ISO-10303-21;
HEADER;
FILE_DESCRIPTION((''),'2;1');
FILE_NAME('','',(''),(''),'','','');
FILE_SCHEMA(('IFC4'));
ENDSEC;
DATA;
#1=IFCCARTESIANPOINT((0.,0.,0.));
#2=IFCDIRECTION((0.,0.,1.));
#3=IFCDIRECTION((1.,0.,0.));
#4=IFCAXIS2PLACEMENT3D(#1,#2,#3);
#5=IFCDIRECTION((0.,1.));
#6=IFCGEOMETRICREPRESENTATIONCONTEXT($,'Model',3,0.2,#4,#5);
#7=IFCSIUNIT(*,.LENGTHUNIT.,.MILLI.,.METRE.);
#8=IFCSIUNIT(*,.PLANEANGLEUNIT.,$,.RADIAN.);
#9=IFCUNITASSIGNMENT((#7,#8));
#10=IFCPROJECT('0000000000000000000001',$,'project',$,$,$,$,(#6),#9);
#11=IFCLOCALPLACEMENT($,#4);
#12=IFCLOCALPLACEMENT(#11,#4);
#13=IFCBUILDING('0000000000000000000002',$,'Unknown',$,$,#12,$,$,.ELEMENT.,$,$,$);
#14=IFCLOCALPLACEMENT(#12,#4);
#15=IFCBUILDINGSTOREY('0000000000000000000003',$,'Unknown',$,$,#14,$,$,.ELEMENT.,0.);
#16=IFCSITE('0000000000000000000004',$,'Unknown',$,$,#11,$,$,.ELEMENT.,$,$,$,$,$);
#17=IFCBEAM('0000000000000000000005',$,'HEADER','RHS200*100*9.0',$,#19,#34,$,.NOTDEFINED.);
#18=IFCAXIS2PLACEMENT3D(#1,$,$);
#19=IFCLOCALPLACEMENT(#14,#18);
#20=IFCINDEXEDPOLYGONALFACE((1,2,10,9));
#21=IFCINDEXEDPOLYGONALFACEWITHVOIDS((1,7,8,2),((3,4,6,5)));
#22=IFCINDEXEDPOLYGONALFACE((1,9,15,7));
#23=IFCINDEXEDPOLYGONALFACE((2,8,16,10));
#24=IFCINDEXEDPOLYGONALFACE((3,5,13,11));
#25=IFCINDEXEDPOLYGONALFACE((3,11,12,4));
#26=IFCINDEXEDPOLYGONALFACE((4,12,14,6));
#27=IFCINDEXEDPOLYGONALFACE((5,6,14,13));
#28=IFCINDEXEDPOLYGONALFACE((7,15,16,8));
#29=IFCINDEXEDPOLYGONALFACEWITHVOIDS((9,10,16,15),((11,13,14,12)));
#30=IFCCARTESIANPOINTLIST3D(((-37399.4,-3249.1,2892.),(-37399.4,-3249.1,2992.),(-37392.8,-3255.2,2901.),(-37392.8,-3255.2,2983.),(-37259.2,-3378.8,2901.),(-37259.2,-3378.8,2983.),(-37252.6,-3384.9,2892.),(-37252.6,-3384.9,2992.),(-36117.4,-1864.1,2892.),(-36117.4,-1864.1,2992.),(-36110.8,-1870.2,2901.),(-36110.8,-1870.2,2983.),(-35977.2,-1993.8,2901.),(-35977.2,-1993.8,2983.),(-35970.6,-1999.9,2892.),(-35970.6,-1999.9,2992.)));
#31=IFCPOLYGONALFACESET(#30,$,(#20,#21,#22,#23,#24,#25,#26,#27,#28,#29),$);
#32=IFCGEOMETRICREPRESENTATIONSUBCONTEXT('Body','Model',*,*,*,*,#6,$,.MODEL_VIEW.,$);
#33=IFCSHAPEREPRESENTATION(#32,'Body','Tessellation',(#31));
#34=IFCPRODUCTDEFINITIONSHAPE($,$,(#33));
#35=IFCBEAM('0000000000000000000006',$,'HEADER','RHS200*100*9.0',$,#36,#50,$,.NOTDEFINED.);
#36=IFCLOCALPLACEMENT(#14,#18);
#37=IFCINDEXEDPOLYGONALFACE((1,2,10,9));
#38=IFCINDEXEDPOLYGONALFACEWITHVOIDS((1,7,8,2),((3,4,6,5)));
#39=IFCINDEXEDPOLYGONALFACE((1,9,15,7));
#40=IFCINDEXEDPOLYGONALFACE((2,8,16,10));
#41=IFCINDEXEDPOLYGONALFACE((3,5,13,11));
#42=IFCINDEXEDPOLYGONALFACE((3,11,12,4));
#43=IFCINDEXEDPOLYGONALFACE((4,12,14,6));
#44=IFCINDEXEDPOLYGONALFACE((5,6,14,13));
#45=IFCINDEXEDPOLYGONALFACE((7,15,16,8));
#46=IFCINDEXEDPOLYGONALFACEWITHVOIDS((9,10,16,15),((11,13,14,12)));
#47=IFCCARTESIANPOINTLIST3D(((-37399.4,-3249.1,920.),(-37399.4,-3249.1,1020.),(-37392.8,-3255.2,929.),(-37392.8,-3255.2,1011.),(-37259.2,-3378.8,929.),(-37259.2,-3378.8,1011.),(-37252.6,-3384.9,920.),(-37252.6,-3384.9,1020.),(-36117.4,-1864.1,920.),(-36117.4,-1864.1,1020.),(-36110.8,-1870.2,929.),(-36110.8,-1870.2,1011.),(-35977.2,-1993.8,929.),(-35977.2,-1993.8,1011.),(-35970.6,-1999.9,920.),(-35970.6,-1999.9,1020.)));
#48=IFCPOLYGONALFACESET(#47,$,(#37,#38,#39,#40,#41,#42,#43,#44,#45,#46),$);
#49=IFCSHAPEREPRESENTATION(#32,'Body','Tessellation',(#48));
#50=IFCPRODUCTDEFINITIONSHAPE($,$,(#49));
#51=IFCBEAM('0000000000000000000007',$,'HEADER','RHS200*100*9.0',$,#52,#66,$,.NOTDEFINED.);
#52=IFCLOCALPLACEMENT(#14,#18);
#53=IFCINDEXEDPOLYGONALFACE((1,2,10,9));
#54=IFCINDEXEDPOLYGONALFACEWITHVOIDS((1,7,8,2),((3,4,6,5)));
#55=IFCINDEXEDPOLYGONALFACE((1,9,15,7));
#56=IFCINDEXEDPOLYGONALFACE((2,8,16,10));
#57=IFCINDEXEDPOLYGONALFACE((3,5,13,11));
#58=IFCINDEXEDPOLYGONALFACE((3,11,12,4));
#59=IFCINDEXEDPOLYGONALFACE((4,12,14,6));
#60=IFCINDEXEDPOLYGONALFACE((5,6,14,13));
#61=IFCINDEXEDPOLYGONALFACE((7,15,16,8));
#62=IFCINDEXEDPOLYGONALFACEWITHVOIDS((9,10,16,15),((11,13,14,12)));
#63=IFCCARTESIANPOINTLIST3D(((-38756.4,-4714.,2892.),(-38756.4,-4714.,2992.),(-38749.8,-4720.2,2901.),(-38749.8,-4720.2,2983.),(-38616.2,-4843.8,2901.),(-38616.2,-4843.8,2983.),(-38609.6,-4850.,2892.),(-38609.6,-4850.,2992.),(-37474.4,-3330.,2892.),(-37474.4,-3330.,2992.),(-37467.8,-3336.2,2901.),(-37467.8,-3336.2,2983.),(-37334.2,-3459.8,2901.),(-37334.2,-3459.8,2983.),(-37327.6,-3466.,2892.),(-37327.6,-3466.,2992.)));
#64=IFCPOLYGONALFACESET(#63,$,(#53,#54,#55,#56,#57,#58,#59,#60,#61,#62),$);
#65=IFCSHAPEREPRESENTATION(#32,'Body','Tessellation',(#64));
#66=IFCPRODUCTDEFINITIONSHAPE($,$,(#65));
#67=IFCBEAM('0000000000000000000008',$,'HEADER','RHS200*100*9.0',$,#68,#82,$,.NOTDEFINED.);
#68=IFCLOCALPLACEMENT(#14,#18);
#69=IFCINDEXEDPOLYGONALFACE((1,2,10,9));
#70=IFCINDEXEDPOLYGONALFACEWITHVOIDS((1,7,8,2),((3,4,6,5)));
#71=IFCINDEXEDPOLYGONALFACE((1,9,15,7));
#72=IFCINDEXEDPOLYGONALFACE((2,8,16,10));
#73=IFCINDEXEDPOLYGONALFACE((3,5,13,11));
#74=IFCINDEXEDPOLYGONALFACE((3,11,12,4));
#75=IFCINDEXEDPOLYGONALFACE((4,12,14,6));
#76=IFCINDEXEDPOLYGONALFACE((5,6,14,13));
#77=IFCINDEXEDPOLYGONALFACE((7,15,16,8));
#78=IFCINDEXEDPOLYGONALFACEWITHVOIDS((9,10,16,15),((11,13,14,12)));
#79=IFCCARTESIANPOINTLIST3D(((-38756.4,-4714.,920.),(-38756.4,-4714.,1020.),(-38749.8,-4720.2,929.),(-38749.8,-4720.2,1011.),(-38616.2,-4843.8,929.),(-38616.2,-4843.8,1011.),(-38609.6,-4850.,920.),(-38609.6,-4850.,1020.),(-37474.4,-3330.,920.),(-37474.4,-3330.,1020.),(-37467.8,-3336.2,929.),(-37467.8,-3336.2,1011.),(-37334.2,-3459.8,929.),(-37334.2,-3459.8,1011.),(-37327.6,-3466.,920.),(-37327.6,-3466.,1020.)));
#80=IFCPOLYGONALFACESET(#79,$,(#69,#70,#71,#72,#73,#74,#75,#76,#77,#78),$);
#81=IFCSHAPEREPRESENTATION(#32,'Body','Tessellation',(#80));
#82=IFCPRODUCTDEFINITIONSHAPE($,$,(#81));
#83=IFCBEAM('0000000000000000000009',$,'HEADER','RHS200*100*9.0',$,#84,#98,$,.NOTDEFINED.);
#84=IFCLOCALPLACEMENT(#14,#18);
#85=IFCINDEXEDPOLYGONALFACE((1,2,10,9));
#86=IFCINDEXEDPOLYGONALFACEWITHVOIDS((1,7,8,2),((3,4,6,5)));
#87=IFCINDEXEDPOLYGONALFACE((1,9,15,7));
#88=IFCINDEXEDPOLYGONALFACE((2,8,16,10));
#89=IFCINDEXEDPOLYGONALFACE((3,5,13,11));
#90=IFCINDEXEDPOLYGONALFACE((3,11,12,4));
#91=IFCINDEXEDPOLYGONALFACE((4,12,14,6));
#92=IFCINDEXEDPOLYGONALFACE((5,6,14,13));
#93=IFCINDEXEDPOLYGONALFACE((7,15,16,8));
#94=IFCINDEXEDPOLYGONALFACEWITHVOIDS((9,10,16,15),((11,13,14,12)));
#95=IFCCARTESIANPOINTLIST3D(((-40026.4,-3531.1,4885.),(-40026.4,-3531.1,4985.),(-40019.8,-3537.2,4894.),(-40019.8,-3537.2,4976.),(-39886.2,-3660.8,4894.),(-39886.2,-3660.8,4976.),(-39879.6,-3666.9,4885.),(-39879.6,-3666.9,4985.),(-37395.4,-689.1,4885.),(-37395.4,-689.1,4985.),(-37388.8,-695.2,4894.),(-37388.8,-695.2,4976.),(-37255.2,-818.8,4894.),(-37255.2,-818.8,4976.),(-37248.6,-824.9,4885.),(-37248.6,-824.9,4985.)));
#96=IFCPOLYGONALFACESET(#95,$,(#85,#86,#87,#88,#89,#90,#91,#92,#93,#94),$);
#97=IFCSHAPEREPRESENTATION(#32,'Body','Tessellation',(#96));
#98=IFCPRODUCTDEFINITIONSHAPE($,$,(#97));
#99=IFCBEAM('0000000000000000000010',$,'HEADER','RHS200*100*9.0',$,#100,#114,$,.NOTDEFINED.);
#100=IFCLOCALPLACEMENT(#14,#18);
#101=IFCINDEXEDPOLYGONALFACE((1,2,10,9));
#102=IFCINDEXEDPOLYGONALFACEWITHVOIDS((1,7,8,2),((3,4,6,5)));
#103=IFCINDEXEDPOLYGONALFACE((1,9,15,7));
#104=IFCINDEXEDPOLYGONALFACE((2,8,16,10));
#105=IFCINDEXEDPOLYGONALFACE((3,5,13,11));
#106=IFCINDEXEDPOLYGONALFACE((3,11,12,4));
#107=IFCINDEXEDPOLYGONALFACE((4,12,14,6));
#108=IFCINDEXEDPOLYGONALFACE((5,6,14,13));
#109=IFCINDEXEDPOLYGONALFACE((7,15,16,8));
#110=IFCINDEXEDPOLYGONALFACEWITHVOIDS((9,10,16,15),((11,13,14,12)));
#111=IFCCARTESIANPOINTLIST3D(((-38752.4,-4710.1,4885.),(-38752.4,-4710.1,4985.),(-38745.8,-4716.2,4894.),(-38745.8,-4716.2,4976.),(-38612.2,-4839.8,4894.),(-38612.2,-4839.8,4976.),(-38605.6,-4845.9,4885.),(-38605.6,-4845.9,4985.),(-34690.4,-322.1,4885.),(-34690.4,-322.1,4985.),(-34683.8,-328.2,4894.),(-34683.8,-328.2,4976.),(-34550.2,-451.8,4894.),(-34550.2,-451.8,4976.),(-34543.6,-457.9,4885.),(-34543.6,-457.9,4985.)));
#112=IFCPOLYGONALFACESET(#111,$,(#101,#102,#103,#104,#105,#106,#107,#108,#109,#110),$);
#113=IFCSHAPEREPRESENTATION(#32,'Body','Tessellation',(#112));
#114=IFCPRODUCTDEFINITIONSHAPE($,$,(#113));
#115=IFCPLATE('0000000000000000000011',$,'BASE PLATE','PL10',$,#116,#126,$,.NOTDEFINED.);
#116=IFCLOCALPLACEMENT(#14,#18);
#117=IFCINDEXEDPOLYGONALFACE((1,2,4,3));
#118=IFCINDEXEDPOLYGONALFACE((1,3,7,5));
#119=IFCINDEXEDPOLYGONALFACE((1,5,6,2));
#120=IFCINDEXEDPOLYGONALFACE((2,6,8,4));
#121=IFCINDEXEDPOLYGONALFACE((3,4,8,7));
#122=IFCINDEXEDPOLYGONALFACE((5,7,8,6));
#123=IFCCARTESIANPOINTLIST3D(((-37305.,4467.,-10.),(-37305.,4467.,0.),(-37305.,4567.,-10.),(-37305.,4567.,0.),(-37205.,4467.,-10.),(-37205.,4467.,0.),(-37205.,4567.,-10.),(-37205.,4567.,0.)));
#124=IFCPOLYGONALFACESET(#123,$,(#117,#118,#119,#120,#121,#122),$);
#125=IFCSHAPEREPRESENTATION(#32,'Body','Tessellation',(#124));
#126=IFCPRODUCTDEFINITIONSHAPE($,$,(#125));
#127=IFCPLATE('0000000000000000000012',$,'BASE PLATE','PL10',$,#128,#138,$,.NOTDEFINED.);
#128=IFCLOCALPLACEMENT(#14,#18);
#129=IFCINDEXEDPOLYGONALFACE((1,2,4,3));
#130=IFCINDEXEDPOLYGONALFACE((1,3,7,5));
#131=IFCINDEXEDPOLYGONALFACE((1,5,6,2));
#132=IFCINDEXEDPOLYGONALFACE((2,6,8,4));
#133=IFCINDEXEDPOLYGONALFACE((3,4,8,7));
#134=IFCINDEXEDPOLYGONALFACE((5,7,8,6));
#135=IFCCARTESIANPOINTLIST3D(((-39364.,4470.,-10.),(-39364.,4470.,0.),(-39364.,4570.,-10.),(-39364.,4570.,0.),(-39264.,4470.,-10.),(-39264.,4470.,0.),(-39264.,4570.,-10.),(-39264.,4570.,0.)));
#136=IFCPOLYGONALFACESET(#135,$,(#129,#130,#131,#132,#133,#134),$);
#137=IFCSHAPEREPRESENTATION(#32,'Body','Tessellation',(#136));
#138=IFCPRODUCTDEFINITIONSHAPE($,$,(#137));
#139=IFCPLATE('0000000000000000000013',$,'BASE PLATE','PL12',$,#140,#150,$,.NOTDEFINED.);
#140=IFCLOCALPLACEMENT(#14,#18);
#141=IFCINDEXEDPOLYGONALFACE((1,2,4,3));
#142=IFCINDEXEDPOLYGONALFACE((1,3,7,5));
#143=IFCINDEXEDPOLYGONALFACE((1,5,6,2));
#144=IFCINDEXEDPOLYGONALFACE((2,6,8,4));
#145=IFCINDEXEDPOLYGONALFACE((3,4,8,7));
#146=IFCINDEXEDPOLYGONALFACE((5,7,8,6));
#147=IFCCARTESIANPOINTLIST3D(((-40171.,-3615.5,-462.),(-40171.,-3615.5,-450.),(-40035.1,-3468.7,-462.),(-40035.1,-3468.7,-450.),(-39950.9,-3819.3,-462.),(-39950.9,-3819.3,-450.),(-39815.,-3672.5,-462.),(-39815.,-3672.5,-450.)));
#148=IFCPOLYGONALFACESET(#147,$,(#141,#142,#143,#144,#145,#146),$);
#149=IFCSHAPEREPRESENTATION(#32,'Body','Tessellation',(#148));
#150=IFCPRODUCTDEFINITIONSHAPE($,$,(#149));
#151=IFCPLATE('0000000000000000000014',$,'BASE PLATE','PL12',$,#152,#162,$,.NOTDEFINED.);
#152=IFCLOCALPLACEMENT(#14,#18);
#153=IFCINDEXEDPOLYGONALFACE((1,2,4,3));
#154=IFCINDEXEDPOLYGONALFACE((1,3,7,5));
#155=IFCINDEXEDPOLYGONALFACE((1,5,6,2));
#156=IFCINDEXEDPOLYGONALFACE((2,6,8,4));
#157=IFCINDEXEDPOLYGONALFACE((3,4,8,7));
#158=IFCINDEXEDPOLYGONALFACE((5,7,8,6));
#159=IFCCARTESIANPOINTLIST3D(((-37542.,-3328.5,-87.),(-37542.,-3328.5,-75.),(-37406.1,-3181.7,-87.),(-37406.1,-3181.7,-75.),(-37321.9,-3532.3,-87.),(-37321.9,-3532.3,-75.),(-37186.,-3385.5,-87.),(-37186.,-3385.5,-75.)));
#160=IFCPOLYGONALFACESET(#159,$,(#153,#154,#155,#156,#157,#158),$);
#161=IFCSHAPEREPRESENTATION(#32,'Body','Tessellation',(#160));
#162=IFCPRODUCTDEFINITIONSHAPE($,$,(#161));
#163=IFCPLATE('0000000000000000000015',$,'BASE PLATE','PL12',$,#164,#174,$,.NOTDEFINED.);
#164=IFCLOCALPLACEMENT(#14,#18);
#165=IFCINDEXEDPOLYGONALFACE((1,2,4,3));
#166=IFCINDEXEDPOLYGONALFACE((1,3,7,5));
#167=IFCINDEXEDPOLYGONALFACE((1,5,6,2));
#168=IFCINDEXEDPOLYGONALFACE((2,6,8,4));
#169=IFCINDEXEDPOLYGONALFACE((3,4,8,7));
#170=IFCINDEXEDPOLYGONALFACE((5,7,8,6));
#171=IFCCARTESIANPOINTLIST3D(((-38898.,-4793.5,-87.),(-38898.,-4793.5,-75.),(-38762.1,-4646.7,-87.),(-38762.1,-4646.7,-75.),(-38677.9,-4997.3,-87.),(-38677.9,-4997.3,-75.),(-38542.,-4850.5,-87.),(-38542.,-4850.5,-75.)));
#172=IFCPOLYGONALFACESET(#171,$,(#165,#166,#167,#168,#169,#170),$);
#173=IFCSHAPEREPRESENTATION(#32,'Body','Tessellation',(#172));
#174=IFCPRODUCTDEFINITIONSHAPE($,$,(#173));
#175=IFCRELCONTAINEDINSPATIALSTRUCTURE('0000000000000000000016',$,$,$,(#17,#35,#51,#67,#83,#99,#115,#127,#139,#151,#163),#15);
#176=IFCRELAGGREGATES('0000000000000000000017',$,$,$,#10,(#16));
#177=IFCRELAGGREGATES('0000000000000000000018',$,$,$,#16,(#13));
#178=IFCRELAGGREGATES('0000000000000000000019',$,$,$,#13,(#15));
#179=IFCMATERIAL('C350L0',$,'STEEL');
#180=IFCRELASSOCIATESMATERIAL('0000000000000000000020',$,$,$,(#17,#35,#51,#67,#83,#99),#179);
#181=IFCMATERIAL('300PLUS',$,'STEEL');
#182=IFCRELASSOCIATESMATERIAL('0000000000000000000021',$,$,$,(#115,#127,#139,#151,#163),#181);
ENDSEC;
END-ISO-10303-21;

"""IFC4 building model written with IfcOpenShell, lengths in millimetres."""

from ifc_helpers import new_model, si_unit, direction, frame, origin_with_axes, place, context, subcontext, project, spatial, line, indexed_curve, outline, extrude, material, element, save


model = new_model("IFC4")

# Units and contexts
model_context = context("Model", 3, precision=0.2, world=origin_with_axes(), true_north=direction((0.0, 1.0)))
body_context = subcontext(model_context, "Body", "Model", "MODEL_VIEW")
ifc_project = project(units=[si_unit("LENGTHUNIT", "METRE", prefix="MILLI"), si_unit("PLANEANGLEUNIT", "RADIAN")], contexts=[model_context])

# Site, building, storey
site_placement = place(None, origin_with_axes())
site = spatial("IfcSite", under=ifc_project, at=site_placement, Name="Unknown", CompositionType="ELEMENT")
building_placement = place(site_placement, origin_with_axes())
building = spatial("IfcBuilding", under=site, at=building_placement, Name="Unknown", CompositionType="ELEMENT")
storey_placement = place(building_placement, origin_with_axes())
storey = spatial("IfcBuildingStorey", under=building, at=storey_placement, Name="Unknown", CompositionType="ELEMENT", Elevation=0.0)

# Shared definitions
ifc_material_1 = material(Name="C350L0", Category="STEEL")

# Beams
for number, where, z_axis, x_axis, name in (
    (1, (-37326.0, -3317.0, 2942.0), (0.0, 0.0, 1.0), (0.679292, 0.733868, 0.0), "HEADER"),
    (2, (-37326.0, -3317.0, 970.0), (0.0, 0.0, 1.0), (0.679292, 0.733868, 0.0), "HEADER"),
):
    element("IfcBeam", number, at=place(storey_placement, frame(where, z_axis=z_axis, x_axis=x_axis)), inside=storey, material=ifc_material_1, Name=name, Description="RHS200*100*9.0", PredefinedType="NOTDEFINED", context=body_context, shape_type="SolidModel", body=[
        extrude(outline(indexed_curve([(-50.0, -100.0), (50.0, -100.0), (50.0, 100.0), (-50.0, 100.0)], segments=[line(1, 2, 3, 4, 1)]), holes=[indexed_curve([(-41.0, -91.0), (-41.0, 91.0), (41.0, 91.0), (41.0, -91.0)], segments=[line(1, 2, 3, 4, 1)])]), frame((0.0, 0.0, 0.0), z_axis=(-1.0, 0.0, 0.0), x_axis=(0.0, 0.0, 1.0)), (0.0, 0.0, -1.0), 1887.3),
    ])
for number, where, z_axis, x_axis, name in (
    (3, (-38683.0, -4782.0, 2942.0), (0.0, 0.0, 1.0), (0.679556, 0.733624, 0.0), "HEADER"),
    (4, (-38683.0, -4782.0, 970.0), (0.0, 0.0, 1.0), (0.679556, 0.733624, 0.0), "HEADER"),
):
    element("IfcBeam", number, at=place(storey_placement, frame(where, z_axis=z_axis, x_axis=x_axis)), inside=storey, material=ifc_material_1, Name=name, Description="RHS200*100*9.0", PredefinedType="NOTDEFINED", context=body_context, shape_type="SolidModel", body=[
        extrude(outline(indexed_curve([(-50.0, -100.0), (50.0, -100.0), (50.0, 100.0), (-50.0, 100.0)], segments=[line(1, 2, 3, 4, 1)]), holes=[indexed_curve([(-41.0, -91.0), (-41.0, 91.0), (41.0, 91.0), (41.0, -91.0)], segments=[line(1, 2, 3, 4, 1)])]), frame((0.0, 0.0, 0.0), z_axis=(-1.0, 0.0, 0.0), x_axis=(0.0, 0.0, 1.0)), (0.0, 0.0, -1.0), 1886.5),
    ])
beam_1_placement = place(storey_placement, frame((-39953.0, -3599.0, 4935.0), z_axis=(0.0, 0.0, 1.0), x_axis=(0.679341, 0.733823, 0.0)))
element("IfcBeam", 5, at=beam_1_placement, inside=storey, material=ifc_material_1, Name="HEADER", Description="RHS200*100*9.0", PredefinedType="NOTDEFINED", context=body_context, shape_type="SolidModel", body=[
    extrude(outline(indexed_curve([(-50.0, -100.0), (50.0, -100.0), (50.0, 100.0), (-50.0, 100.0)], segments=[line(1, 2, 3, 4, 1)]), holes=[indexed_curve([(-41.0, -91.0), (-41.0, 91.0), (41.0, 91.0), (41.0, -91.0)], segments=[line(1, 2, 3, 4, 1)])]), frame((0.0, 0.0, 0.0), z_axis=(-1.0, 0.0, 0.0), x_axis=(0.0, 0.0, 1.0)), (0.0, 0.0, -1.0), 3872.9),
])
beam_2_placement = place(storey_placement, frame((-38679.0, -4778.0, 4935.0), z_axis=(0.0, 0.0, 1.0), x_axis=(0.679321, 0.733841, 0.0)))
element("IfcBeam", 6, at=beam_2_placement, inside=storey, material=ifc_material_1, Name="HEADER", Description="RHS200*100*9.0", PredefinedType="NOTDEFINED", context=body_context, shape_type="SolidModel", body=[
    extrude(outline(indexed_curve([(-50.0, -100.0), (50.0, -100.0), (50.0, 100.0), (-50.0, 100.0)], segments=[line(1, 2, 3, 4, 1)]), holes=[indexed_curve([(-41.0, -91.0), (-41.0, 91.0), (41.0, 91.0), (41.0, -91.0)], segments=[line(1, 2, 3, 4, 1)])]), frame((0.0, 0.0, 0.0), z_axis=(-1.0, 0.0, 0.0), x_axis=(0.0, 0.0, 1.0)), (0.0, 0.0, -1.0), 5979.5),
])

# Plates
ifc_material_2 = material(Name="300PLUS", Category="STEEL")
for number, where, z_axis, x_axis, name in (
    (7, (-37305.0, 4467.0, -5.0), (0.0, 0.0, 1.0), (1.0, 0.0, 0.0), "BASE PLATE"),
    (8, (-39364.0, 4470.0, -5.0), (0.0, 0.0, 1.0), (1.0, 0.0, 0.0), "BASE PLATE"),
):
    element("IfcPlate", number, at=place(storey_placement, frame(where, z_axis=z_axis, x_axis=x_axis)), inside=storey, material=ifc_material_2, Name=name, Description="PL10", PredefinedType="NOTDEFINED", context=body_context, shape_type="SolidModel", body=[
        extrude(outline(indexed_curve([(0.0, 0.0), (100.0, 0.0), (100.0, 100.0), (0.0, 100.0)], segments=[line(1, 2, 3, 4, 1)])), frame((0.0, 0.0, 5.0), z_axis=(0.0, 0.0, 1.0), x_axis=(1.0, 0.0, 0.0)), (0.0, 0.0, -1.0), 10.0),
    ])
for number, where, z_axis, x_axis, name in (
    (9, (-39815.0, -3672.5, -456.0), (0.0, 0.0, 1.0), (-0.733755, 0.679415, 0.0), "BASE PLATE"),
    (10, (-37186.0, -3385.5, -81.0), (0.0, 0.0, 1.0), (-0.733755, 0.679415, 0.0), "BASE PLATE"),
    (11, (-38542.0, -4850.5, -81.0), (0.0, 0.0, 1.0), (-0.733755, 0.679415, 0.0), "BASE PLATE"),
):
    element("IfcPlate", number, at=place(storey_placement, frame(where, z_axis=z_axis, x_axis=x_axis)), inside=storey, material=ifc_material_2, Name=name, Description="PL12", PredefinedType="NOTDEFINED", context=body_context, shape_type="SolidModel", body=[
        extrude(outline(indexed_curve([(0.0, 0.0), (300.0, 0.0), (299.9, 200.0), (0.0, 200.0)], segments=[line(1, 2, 3, 4, 1)])), frame((0.0, 0.0, 6.0), z_axis=(0.0, 0.0, 1.0), x_axis=(1.0, 0.0, 0.0)), (0.0, 0.0, -1.0), 12.0),
    ])

save(model, "model.ifc")
